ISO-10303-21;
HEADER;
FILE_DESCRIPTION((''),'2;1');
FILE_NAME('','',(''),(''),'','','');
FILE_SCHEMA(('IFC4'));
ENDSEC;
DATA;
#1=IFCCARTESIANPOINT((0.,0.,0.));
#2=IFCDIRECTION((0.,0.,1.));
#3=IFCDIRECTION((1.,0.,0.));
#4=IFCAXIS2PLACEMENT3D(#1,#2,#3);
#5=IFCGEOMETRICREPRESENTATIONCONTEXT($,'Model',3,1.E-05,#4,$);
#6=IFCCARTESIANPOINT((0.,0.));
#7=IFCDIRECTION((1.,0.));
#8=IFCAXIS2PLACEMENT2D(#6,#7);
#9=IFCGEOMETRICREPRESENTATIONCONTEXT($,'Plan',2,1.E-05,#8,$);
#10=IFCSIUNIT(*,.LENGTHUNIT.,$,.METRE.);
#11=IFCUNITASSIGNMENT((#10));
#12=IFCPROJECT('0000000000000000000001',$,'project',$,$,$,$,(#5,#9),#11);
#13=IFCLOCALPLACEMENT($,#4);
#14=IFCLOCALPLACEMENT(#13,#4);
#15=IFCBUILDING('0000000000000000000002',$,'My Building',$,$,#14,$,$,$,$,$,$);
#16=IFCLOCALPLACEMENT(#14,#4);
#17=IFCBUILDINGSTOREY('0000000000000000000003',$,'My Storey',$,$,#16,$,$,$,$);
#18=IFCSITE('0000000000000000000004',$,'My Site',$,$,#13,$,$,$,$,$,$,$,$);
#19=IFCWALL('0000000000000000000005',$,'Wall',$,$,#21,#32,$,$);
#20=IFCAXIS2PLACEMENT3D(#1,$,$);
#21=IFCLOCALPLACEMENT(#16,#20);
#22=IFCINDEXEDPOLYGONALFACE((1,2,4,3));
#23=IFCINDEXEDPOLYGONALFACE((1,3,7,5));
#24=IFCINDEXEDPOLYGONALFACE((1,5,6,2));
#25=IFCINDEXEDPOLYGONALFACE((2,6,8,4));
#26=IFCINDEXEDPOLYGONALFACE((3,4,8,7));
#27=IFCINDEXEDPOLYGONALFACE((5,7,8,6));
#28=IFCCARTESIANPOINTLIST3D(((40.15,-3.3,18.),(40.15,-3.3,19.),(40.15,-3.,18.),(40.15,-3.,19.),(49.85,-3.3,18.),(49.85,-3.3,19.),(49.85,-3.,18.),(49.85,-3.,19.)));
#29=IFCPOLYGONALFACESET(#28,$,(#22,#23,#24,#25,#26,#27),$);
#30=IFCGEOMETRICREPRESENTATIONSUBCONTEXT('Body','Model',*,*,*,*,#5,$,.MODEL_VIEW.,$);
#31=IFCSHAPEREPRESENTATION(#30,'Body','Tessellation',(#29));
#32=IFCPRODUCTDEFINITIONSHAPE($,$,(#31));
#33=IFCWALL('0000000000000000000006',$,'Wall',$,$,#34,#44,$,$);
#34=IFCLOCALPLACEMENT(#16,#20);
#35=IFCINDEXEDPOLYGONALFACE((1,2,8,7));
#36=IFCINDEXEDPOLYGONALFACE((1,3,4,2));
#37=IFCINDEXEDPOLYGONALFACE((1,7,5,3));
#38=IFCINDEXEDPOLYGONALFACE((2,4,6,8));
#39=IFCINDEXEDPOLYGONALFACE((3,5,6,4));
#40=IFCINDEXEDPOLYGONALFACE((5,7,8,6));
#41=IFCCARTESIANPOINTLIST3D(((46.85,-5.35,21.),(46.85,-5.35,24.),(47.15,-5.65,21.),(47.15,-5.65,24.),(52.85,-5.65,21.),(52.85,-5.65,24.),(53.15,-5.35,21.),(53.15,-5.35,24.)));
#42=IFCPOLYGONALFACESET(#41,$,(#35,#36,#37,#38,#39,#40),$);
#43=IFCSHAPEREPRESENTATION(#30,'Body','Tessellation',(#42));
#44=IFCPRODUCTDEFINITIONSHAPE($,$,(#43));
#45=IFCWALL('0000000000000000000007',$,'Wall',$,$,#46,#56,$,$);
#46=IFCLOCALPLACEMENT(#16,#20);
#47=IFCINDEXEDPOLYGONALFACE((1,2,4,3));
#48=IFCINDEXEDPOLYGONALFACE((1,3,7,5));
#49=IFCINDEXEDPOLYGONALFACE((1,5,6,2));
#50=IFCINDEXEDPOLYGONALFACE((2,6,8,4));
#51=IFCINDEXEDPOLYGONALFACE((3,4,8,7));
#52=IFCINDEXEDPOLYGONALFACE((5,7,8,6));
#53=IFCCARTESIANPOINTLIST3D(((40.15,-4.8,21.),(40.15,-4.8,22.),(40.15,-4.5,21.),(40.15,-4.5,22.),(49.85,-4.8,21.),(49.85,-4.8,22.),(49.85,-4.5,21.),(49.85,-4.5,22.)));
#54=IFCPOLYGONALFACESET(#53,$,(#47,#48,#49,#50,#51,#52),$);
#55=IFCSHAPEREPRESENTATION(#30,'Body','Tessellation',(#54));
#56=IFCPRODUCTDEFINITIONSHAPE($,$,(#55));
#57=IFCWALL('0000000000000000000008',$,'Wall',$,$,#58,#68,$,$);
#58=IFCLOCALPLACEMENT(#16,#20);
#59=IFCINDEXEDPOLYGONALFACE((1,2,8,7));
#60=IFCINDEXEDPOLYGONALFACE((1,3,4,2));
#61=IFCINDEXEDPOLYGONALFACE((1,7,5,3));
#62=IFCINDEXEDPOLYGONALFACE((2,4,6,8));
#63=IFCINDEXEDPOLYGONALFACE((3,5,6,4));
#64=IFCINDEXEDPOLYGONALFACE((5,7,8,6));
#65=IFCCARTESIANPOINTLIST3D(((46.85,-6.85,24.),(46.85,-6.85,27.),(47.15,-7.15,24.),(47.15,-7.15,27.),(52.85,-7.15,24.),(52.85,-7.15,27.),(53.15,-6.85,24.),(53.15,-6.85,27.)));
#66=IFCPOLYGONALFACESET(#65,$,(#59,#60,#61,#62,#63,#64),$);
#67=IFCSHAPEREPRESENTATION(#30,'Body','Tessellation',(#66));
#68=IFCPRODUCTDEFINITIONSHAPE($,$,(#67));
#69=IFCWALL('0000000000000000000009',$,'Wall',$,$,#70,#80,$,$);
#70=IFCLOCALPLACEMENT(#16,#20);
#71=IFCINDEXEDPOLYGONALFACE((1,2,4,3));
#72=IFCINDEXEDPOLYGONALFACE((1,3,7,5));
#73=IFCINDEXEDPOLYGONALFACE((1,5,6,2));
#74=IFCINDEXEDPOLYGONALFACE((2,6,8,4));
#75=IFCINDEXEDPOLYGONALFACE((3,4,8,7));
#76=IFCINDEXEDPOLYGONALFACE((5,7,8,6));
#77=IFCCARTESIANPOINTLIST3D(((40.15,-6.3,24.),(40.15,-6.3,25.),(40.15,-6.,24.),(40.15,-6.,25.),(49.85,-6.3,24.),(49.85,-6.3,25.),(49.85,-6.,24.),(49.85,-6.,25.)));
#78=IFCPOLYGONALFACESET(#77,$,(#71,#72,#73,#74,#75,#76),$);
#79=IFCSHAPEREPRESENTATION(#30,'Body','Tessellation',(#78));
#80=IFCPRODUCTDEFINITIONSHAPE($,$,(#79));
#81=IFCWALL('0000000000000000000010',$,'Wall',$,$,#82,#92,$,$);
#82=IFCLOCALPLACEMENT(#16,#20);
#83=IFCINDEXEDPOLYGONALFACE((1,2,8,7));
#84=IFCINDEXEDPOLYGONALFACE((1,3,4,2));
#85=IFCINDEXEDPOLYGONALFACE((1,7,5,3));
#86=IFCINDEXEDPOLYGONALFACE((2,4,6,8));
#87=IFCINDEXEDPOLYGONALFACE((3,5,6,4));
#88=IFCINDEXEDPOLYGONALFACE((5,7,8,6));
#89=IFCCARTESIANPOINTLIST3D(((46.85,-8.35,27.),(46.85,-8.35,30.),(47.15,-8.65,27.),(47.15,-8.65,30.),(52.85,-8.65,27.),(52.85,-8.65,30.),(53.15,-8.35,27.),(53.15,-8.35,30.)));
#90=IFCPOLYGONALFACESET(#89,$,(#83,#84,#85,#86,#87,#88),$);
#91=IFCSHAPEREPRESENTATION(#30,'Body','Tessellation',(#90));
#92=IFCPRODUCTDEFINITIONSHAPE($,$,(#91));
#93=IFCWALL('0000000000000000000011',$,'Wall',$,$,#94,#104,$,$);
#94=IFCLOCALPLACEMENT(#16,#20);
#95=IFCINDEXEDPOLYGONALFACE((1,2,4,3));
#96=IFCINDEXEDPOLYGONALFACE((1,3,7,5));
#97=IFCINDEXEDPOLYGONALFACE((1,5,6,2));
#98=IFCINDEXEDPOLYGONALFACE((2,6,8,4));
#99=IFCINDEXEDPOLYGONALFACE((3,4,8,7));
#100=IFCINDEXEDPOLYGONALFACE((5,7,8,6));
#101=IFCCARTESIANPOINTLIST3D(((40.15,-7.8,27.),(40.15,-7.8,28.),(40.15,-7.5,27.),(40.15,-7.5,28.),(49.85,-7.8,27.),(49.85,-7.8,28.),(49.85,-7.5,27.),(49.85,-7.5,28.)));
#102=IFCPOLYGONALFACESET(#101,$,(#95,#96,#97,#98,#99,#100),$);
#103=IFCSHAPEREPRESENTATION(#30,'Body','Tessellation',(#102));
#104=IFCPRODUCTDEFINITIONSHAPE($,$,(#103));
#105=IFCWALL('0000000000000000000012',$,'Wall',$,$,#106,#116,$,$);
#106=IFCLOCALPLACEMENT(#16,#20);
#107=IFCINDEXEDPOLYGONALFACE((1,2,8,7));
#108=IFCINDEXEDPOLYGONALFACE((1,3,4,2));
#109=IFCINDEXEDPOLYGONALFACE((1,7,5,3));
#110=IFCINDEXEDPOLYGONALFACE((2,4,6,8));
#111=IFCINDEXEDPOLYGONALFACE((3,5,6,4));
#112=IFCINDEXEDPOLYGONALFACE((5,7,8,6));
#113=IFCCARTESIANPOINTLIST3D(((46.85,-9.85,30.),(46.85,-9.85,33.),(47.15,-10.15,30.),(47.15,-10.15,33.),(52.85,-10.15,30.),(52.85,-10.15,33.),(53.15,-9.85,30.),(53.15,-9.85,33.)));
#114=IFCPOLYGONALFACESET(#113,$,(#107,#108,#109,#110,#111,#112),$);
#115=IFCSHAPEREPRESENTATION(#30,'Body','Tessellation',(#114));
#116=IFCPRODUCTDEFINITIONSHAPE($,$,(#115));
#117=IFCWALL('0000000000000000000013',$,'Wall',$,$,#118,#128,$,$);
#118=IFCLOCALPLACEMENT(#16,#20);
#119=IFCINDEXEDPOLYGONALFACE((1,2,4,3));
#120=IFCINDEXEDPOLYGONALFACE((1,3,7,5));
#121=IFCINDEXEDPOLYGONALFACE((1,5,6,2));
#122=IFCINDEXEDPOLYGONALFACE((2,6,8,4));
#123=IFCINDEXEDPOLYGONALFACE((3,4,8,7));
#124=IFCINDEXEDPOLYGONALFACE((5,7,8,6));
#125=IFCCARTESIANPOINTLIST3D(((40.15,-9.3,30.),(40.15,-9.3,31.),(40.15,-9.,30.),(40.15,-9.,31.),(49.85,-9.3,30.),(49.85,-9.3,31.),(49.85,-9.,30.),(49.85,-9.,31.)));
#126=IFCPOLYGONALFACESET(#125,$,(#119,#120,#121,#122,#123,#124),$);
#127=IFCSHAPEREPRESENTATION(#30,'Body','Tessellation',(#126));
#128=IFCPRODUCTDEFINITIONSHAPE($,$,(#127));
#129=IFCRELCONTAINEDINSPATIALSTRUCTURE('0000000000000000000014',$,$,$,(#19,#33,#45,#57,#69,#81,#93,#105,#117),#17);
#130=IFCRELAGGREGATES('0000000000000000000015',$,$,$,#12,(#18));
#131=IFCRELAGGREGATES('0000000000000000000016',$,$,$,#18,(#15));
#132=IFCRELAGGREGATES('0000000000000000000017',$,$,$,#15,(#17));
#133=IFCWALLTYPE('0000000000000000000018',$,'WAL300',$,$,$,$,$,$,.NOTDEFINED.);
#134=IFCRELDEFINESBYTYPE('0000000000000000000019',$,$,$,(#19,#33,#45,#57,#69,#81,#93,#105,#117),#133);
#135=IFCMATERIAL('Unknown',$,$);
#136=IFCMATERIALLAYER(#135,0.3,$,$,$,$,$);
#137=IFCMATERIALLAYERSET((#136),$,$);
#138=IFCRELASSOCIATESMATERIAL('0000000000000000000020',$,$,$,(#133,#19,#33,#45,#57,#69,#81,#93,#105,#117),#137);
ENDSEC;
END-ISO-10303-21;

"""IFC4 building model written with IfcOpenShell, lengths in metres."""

from ifc_helpers import new_model, si_unit, frame, origin_with_axes, origin_2d_with_axis, place, context, subcontext, project, spatial, line, indexed_curve, outline, extrude, material, layer, layer_set, layer_usage, type_object, element, save


model = new_model("IFC4")

# Units and contexts
model_context = context("Model", 3, precision=1e-05, world=origin_with_axes())
plan_context = context("Plan", 2, precision=1e-05, world=origin_2d_with_axis())
body_context = subcontext(model_context, "Body", "Model", "MODEL_VIEW")
ifc_project = project(units=[si_unit("LENGTHUNIT", "METRE")], contexts=[model_context, plan_context])

# Site, building, storey
site_placement = place(None, origin_with_axes())
site = spatial("IfcSite", under=ifc_project, at=site_placement, Name="My Site")
building_placement = place(site_placement, origin_with_axes())
building = spatial("IfcBuilding", under=site, at=building_placement, Name="My Building")
storey_placement = place(building_placement, origin_with_axes())
storey = spatial("IfcBuildingStorey", under=building, at=storey_placement, Name="My Storey")

# Shared definitions
ifc_material = material(Name="Unknown")

# Walls
ifc_layer_1 = layer(ifc_material, 0.3)
ifc_layer_set_1 = layer_set([ifc_layer_1])
wall_type = type_object("IfcWallType", Name="WAL300", PredefinedType="NOTDEFINED", material=ifc_layer_set_1)
ifc_layer_usage_1 = layer_usage(ifc_layer_set_1, "AXIS2", "POSITIVE", -0.3)
wall_1_placement = place(storey_placement, frame((40.15, -3.0, 18.0), z_axis=(0.0, 0.0, 1.0), x_axis=(1.0, 0.0, 0.0)))
element("IfcWall", 1, at=wall_1_placement, inside=storey, type_object=wall_type, material=ifc_layer_usage_1, Name="Wall", context=body_context, shape_type="SweptSolid", body=[
    extrude(outline(indexed_curve([(0.0, -0.3), (0.0, 0.0), (9.7, 0.0), (9.7, -0.3)], segments=[line(1, 2, 3, 4, 1)])), origin_with_axes(), (0.0, 0.0, 1.0), 1.0),
])
ifc_layer_usage_2 = layer_usage(ifc_layer_set_1, "AXIS2", "POSITIVE", -0.15)
wall_2_placement = place(storey_placement, frame((47.0, -5.5, 21.0), z_axis=(0.0, 0.0, 1.0), x_axis=(1.0, 0.0, 0.0)))
element("IfcWall", 2, at=wall_2_placement, inside=storey, type_object=wall_type, material=ifc_layer_usage_2, Name="Wall", context=body_context, shape_type="SweptSolid", body=[
    extrude(outline(indexed_curve([(0.15, -0.15), (-0.15, 0.15), (6.15, 0.15), (5.85, -0.15)], segments=[line(1, 2, 3, 4, 1)])), origin_with_axes(), (0.0, 0.0, 1.0), 3.0),
])
ifc_layer_usage_3 = layer_usage(ifc_layer_set_1, "AXIS2", "POSITIVE", -0.3)
wall_3_placement = place(storey_placement, frame((40.15, -4.5, 21.0), z_axis=(0.0, 0.0, 1.0), x_axis=(1.0, 0.0, 0.0)))
element("IfcWall", 3, at=wall_3_placement, inside=storey, type_object=wall_type, material=ifc_layer_usage_3, Name="Wall", context=body_context, shape_type="SweptSolid", body=[
    extrude(outline(indexed_curve([(0.0, -0.3), (0.0, 0.0), (9.7, 0.0), (9.7, -0.3)], segments=[line(1, 2, 3, 4, 1)])), origin_with_axes(), (0.0, 0.0, 1.0), 1.0),
])
ifc_layer_usage_4 = layer_usage(ifc_layer_set_1, "AXIS2", "POSITIVE", -0.15)
wall_4_placement = place(storey_placement, frame((47.0, -7.0, 24.0), z_axis=(0.0, 0.0, 1.0), x_axis=(1.0, 0.0, 0.0)))
element("IfcWall", 4, at=wall_4_placement, inside=storey, type_object=wall_type, material=ifc_layer_usage_4, Name="Wall", context=body_context, shape_type="SweptSolid", body=[
    extrude(outline(indexed_curve([(0.15, -0.15), (-0.15, 0.15), (6.15, 0.15), (5.85, -0.15)], segments=[line(1, 2, 3, 4, 1)])), origin_with_axes(), (0.0, 0.0, 1.0), 3.0),
])
ifc_layer_usage_5 = layer_usage(ifc_layer_set_1, "AXIS2", "POSITIVE", -0.3)
wall_5_placement = place(storey_placement, frame((40.15, -6.0, 24.0), z_axis=(0.0, 0.0, 1.0), x_axis=(1.0, 0.0, 0.0)))
element("IfcWall", 5, at=wall_5_placement, inside=storey, type_object=wall_type, material=ifc_layer_usage_5, Name="Wall", context=body_context, shape_type="SweptSolid", body=[
    extrude(outline(indexed_curve([(0.0, -0.3), (0.0, 0.0), (9.7, 0.0), (9.7, -0.3)], segments=[line(1, 2, 3, 4, 1)])), origin_with_axes(), (0.0, 0.0, 1.0), 1.0),
])
ifc_layer_usage_6 = layer_usage(ifc_layer_set_1, "AXIS2", "POSITIVE", -0.15)
wall_6_placement = place(storey_placement, frame((47.0, -8.5, 27.0), z_axis=(0.0, 0.0, 1.0), x_axis=(1.0, 0.0, 0.0)))
element("IfcWall", 6, at=wall_6_placement, inside=storey, type_object=wall_type, material=ifc_layer_usage_6, Name="Wall", context=body_context, shape_type="SweptSolid", body=[
    extrude(outline(indexed_curve([(0.15, -0.15), (-0.15, 0.15), (6.15, 0.15), (5.85, -0.15)], segments=[line(1, 2, 3, 4, 1)])), origin_with_axes(), (0.0, 0.0, 1.0), 3.0),
])
ifc_layer_usage_7 = layer_usage(ifc_layer_set_1, "AXIS2", "POSITIVE", -0.3)
wall_7_placement = place(storey_placement, frame((40.15, -7.5, 27.0), z_axis=(0.0, 0.0, 1.0), x_axis=(1.0, 0.0, 0.0)))
element("IfcWall", 7, at=wall_7_placement, inside=storey, type_object=wall_type, material=ifc_layer_usage_7, Name="Wall", context=body_context, shape_type="SweptSolid", body=[
    extrude(outline(indexed_curve([(0.0, -0.3), (0.0, 0.0), (9.7, 0.0), (9.7, -0.3)], segments=[line(1, 2, 3, 4, 1)])), origin_with_axes(), (0.0, 0.0, 1.0), 1.0),
])
ifc_layer_usage_8 = layer_usage(ifc_layer_set_1, "AXIS2", "POSITIVE", -0.15)
wall_8_placement = place(storey_placement, frame((47.0, -10.0, 30.0), z_axis=(0.0, 0.0, 1.0), x_axis=(1.0, 0.0, 0.0)))
element("IfcWall", 8, at=wall_8_placement, inside=storey, type_object=wall_type, material=ifc_layer_usage_8, Name="Wall", context=body_context, shape_type="SweptSolid", body=[
    extrude(outline(indexed_curve([(0.15, -0.15), (-0.15, 0.15), (6.15, 0.15), (5.85, -0.15)], segments=[line(1, 2, 3, 4, 1)])), origin_with_axes(), (0.0, 0.0, 1.0), 3.0),
])
ifc_layer_usage_9 = layer_usage(ifc_layer_set_1, "AXIS2", "POSITIVE", -0.3)
wall_9_placement = place(storey_placement, frame((40.15, -9.0, 30.0), z_axis=(0.0, 0.0, 1.0), x_axis=(1.0, 0.0, 0.0)))
element("IfcWall", 9, at=wall_9_placement, inside=storey, type_object=wall_type, material=ifc_layer_usage_9, Name="Wall", context=body_context, shape_type="SweptSolid", body=[
    extrude(outline(indexed_curve([(0.0, -0.3), (0.0, 0.0), (9.7, 0.0), (9.7, -0.3)], segments=[line(1, 2, 3, 4, 1)])), origin_with_axes(), (0.0, 0.0, 1.0), 1.0),
])

save(model, "model.ifc")
